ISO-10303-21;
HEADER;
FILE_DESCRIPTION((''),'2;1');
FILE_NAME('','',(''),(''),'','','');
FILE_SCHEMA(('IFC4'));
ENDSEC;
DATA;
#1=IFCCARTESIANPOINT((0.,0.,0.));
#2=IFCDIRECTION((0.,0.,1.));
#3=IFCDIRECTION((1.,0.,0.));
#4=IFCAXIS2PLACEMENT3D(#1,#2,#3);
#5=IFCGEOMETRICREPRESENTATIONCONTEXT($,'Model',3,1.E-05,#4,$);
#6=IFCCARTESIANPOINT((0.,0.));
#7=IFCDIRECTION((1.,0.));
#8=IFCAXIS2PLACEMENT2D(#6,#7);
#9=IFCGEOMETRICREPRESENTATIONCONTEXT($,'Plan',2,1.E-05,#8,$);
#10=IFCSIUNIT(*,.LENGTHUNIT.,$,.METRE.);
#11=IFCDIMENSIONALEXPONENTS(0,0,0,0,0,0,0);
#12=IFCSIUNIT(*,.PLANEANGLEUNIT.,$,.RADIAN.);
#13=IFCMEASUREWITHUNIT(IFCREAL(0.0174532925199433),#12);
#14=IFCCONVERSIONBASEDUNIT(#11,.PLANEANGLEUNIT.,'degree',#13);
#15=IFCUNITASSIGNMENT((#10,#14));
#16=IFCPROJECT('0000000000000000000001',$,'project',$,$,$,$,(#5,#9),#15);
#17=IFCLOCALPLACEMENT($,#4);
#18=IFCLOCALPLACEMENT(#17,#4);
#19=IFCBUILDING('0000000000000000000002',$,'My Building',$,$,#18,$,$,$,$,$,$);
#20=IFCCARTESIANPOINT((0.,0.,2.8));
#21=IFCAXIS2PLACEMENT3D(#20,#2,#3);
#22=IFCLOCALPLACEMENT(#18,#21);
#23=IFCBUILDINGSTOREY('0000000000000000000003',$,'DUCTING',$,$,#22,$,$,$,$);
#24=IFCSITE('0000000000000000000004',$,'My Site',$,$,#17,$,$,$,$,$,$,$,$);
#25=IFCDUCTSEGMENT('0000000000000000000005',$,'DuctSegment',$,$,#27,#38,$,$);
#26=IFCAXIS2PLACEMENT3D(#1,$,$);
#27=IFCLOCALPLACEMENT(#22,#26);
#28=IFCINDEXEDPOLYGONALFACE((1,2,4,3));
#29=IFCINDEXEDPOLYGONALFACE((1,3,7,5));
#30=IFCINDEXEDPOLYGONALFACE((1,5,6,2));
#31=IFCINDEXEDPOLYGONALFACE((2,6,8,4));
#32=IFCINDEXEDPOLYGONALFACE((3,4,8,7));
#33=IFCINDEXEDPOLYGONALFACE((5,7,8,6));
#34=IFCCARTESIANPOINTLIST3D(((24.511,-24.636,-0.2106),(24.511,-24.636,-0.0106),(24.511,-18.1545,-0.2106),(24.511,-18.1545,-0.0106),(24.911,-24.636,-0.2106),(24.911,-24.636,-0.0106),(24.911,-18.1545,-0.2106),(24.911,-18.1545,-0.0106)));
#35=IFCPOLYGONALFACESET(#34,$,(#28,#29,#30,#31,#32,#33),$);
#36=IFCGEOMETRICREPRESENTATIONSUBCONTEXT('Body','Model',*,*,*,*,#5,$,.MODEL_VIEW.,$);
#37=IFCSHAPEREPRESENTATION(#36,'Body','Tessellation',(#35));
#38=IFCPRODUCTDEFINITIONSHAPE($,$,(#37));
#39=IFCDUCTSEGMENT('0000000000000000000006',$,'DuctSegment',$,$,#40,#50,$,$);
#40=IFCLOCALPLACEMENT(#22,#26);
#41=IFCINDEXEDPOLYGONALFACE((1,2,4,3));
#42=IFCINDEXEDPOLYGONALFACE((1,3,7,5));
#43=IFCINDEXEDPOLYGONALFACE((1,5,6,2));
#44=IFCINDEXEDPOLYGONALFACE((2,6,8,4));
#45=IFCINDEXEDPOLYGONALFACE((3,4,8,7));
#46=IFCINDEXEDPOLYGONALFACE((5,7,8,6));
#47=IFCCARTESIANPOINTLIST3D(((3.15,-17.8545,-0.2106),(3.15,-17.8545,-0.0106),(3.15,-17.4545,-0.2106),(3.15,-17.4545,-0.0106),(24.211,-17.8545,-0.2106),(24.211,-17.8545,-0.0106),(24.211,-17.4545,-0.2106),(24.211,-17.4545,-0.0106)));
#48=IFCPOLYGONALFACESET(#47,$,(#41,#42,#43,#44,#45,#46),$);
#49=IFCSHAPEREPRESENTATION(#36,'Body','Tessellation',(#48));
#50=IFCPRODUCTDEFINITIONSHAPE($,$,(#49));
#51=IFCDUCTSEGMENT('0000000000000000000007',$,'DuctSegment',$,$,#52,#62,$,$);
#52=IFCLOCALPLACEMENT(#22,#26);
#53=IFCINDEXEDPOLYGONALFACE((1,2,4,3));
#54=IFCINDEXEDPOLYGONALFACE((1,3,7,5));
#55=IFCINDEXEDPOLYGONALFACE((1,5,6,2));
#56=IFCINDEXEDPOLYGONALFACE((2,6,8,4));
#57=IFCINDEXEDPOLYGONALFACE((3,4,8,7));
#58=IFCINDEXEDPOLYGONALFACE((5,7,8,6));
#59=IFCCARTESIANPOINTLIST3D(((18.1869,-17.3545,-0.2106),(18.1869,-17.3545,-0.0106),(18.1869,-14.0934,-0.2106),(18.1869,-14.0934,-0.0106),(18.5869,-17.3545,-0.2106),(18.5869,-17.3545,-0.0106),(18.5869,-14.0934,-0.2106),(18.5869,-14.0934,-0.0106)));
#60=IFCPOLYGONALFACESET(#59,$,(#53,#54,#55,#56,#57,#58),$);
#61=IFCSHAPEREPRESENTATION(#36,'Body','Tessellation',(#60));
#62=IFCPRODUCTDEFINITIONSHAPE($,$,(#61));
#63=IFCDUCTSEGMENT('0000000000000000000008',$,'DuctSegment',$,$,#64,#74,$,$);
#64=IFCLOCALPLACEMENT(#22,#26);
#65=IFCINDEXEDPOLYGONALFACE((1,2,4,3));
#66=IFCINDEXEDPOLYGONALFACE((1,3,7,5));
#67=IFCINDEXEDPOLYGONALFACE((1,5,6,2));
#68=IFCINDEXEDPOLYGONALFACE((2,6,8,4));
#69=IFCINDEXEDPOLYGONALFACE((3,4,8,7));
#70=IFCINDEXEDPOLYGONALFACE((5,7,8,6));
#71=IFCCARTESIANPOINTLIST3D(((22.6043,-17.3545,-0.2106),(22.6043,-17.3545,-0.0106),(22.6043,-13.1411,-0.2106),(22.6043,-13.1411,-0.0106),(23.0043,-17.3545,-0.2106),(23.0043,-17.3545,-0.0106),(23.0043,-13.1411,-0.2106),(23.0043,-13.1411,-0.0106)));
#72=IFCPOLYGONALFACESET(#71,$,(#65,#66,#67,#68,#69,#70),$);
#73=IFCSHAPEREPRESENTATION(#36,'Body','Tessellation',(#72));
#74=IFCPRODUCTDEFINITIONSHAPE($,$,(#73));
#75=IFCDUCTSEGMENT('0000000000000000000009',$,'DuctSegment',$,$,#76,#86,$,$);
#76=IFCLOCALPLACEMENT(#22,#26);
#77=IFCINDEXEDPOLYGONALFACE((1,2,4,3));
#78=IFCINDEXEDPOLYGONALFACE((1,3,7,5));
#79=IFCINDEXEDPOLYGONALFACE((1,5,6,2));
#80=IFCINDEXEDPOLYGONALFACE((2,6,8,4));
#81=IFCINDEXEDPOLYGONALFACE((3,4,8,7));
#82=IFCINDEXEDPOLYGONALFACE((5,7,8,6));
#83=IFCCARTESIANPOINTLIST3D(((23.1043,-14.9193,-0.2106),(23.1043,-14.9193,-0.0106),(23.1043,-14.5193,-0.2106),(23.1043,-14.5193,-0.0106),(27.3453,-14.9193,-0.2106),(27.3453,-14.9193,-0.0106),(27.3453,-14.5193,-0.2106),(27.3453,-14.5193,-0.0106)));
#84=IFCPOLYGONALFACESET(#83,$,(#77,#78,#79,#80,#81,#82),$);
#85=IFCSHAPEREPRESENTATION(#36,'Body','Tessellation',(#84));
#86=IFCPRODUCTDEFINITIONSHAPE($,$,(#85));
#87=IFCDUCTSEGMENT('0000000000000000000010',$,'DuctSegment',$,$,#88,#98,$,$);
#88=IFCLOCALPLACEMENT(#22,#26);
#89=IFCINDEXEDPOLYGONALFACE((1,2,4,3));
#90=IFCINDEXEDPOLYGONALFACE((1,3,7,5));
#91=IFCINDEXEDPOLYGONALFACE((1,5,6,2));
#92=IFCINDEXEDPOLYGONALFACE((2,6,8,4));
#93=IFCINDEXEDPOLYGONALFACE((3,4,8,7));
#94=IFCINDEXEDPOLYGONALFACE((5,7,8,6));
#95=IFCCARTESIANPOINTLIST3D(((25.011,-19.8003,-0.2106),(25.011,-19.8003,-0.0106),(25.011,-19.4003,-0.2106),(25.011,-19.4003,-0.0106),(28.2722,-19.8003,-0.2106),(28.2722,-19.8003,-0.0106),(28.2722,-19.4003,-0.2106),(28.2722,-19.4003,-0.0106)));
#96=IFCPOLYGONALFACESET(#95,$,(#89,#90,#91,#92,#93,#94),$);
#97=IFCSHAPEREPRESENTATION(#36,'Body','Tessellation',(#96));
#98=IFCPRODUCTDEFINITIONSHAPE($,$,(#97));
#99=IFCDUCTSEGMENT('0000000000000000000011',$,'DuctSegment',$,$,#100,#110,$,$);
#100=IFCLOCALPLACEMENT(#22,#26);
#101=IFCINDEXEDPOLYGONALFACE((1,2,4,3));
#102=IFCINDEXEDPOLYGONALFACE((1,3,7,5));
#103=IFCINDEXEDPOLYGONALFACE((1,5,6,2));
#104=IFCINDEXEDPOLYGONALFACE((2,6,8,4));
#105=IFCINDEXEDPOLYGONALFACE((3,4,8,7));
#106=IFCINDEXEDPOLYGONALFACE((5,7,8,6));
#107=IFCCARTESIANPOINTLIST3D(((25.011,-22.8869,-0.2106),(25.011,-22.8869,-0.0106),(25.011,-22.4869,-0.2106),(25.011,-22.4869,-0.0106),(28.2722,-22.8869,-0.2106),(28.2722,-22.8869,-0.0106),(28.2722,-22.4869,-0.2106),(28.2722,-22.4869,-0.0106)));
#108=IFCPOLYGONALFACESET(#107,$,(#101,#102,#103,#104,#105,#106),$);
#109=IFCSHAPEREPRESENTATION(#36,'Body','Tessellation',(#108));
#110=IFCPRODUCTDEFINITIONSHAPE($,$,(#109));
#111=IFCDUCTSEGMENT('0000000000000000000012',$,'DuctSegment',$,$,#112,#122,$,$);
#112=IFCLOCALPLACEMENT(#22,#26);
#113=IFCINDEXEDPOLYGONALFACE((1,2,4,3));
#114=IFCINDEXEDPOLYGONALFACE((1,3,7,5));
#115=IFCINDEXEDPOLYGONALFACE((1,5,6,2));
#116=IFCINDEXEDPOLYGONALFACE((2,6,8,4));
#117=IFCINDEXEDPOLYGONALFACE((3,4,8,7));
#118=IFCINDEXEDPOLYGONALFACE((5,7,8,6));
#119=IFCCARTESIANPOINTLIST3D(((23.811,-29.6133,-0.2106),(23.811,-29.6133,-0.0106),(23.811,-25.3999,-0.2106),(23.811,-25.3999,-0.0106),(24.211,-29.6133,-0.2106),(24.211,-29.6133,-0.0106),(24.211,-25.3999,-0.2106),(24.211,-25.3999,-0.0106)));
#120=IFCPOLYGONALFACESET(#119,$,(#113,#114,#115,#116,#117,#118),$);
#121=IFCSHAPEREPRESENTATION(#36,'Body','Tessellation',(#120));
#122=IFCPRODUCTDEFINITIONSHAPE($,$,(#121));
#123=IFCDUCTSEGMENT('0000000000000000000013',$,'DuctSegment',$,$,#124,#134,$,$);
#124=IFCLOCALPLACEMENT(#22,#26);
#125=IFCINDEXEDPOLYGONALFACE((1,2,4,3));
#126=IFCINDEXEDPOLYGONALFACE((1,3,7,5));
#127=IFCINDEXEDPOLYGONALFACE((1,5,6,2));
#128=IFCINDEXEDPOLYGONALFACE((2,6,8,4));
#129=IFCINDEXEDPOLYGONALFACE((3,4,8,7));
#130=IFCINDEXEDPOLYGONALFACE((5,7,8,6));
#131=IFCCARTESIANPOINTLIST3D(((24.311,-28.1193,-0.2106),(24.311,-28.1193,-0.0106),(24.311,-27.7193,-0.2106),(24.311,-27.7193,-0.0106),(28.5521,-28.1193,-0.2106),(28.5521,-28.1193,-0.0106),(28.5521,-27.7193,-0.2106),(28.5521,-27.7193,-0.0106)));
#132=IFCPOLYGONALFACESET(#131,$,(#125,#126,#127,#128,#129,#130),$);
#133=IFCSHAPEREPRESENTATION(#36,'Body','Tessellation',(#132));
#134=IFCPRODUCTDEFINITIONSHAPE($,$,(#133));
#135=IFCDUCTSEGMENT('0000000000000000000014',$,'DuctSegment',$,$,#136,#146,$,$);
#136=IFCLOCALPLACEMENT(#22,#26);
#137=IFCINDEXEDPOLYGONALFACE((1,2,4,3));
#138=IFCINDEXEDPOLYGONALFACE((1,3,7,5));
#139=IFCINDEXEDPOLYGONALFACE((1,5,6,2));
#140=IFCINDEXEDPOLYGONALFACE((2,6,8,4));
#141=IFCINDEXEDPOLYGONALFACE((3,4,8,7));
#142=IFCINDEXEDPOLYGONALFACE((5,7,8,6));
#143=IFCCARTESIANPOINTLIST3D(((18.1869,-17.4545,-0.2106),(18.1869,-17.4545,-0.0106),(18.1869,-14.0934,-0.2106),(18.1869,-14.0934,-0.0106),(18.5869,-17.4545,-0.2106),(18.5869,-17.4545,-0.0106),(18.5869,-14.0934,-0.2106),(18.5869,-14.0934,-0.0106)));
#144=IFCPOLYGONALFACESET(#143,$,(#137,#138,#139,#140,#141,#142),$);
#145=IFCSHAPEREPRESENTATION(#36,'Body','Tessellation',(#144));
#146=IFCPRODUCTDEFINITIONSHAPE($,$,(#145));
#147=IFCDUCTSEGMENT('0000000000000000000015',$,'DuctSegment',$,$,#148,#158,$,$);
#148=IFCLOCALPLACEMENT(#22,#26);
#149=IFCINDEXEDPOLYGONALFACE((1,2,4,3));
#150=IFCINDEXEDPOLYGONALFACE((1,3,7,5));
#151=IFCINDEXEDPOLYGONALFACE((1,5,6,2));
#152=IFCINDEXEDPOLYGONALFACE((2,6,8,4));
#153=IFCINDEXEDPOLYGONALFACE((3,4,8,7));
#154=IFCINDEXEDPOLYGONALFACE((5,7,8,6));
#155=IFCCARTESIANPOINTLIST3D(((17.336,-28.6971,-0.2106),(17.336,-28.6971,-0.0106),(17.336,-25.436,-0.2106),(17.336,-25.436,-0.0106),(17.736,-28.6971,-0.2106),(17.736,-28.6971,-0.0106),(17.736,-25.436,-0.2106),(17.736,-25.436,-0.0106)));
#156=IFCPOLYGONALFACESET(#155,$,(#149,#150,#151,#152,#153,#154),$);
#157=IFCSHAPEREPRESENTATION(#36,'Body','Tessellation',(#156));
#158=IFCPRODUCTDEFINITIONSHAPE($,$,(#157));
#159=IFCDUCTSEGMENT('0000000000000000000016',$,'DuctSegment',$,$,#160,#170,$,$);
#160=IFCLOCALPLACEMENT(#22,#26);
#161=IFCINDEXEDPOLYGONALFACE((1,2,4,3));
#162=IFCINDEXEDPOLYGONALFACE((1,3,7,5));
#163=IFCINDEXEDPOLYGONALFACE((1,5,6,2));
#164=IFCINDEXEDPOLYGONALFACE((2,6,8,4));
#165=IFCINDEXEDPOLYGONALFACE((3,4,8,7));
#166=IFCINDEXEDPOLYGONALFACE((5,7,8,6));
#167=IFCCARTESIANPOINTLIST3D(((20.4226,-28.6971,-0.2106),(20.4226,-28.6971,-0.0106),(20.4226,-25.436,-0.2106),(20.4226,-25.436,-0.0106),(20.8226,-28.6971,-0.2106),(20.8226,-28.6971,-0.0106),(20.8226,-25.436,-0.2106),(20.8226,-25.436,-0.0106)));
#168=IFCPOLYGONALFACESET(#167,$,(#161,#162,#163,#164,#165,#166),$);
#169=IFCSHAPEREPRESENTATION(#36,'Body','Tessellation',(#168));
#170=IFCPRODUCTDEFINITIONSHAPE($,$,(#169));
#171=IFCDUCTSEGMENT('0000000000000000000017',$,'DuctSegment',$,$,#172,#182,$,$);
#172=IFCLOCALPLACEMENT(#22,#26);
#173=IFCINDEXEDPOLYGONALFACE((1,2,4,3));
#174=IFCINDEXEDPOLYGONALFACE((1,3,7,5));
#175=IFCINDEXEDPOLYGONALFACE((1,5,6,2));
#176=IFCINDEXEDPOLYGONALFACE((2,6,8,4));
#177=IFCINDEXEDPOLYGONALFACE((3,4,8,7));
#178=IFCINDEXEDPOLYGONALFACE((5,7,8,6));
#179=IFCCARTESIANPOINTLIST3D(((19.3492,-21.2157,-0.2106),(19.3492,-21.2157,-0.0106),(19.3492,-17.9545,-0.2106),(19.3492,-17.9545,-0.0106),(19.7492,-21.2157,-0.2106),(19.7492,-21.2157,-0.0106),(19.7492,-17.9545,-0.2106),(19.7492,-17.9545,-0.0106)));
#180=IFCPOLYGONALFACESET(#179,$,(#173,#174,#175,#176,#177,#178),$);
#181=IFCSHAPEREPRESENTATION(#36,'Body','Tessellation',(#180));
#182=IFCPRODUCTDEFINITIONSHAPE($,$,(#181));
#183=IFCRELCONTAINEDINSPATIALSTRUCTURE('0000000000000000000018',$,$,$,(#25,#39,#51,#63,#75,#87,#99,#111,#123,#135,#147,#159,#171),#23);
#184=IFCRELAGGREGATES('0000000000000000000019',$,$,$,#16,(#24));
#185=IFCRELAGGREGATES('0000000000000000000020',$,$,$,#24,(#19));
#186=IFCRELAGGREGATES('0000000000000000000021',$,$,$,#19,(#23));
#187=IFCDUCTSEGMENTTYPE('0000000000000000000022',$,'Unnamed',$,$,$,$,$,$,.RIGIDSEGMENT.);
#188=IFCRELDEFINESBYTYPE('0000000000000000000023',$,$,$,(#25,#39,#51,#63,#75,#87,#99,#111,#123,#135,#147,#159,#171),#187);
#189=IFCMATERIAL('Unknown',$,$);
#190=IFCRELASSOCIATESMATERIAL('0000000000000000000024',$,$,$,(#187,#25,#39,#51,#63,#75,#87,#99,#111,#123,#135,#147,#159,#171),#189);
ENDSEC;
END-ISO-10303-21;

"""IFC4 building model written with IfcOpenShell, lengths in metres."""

from ifc_helpers import new_model, entity, si_unit, converted_unit, frame, origin_with_axes, origin_2d_with_axis, place, context, subcontext, project, spatial, rectangle, extrude, material, material_profile, profile_set, profile_usage, type_object, element, save


model = new_model("IFC4")

# Units and contexts
model_context = context("Model", 3, precision=1e-05, world=origin_with_axes())
plan_context = context("Plan", 2, precision=1e-05, world=origin_2d_with_axis())
body_context = subcontext(model_context, "Body", "Model", "MODEL_VIEW")
ifc_project = project(units=[si_unit("LENGTHUNIT", "METRE"), converted_unit("PLANEANGLEUNIT", "degree", entity("IfcReal", 0.0174532925199433), si_unit("PLANEANGLEUNIT", "RADIAN"), dimensions=[0, 0, 0, 0, 0, 0, 0])], contexts=[model_context, plan_context])

# Site, building, storey
site_placement = place(None, origin_with_axes())
site = spatial("IfcSite", under=ifc_project, at=site_placement, Name="My Site")
building_placement = place(site_placement, origin_with_axes())
building = spatial("IfcBuilding", under=site, at=building_placement, Name="My Building")
storey_placement = place(building_placement, frame((0.0, 0.0, 2.8), z_axis=(0.0, 0.0, 1.0), x_axis=(1.0, 0.0, 0.0)))
storey = spatial("IfcBuildingStorey", under=building, at=storey_placement, Name="DUCTING")

# Duct segments
ifc_material = material(Name="Unknown")
ifc_material_profile_1 = material_profile(ifc_material, rectangle(XDim=0.4, YDim=0.2))
ifc_profile_set_1 = profile_set([ifc_material_profile_1])
ifc_profile_usage_1 = profile_usage(ifc_profile_set_1, cardinal=5)
duct_segment_type = type_object("IfcDuctSegmentType", Name="Unnamed", PredefinedType="RIGIDSEGMENT", material=ifc_profile_set_1)
duct_segment_1_placement = place(storey_placement, frame((24.711, -24.636, -0.1106), z_axis=(0.0, 1.0, 0.0), x_axis=(-1.0, 0.0, 0.0)))
element("IfcDuctSegment", 1, at=duct_segment_1_placement, inside=storey, type_object=duct_segment_type, material=ifc_profile_usage_1, Name="DuctSegment", context=body_context, shape_type="SweptSolid", body=[
    extrude(rectangle(XDim=0.4, YDim=0.2), origin_with_axes(), (0.0, 0.0, 1.0), 6.4815),
])
ifc_profile_usage_2 = profile_usage(ifc_profile_set_1, cardinal=5)
duct_segment_2_placement = place(storey_placement, frame((24.211, -17.6545, -0.1106), z_axis=(-1.0, 0.0, 0.0), x_axis=(0.0, -1.0, 0.0)))
element("IfcDuctSegment", 2, at=duct_segment_2_placement, inside=storey, type_object=duct_segment_type, material=ifc_profile_usage_2, Name="DuctSegment", context=body_context, shape_type="SweptSolid", body=[
    extrude(rectangle(XDim=0.4, YDim=0.2), origin_with_axes(), (0.0, 0.0, 1.0), 21.061),
])
ifc_profile_usage_3 = profile_usage(ifc_profile_set_1, cardinal=5)
duct_segment_3_placement = place(storey_placement, frame((18.3869, -17.3545, -0.1106), z_axis=(0.0, 1.0, 0.0), x_axis=(-1.0, 0.0, 0.0)))
element("IfcDuctSegment", 3, at=duct_segment_3_placement, inside=storey, type_object=duct_segment_type, material=ifc_profile_usage_3, Name="DuctSegment", context=body_context, shape_type="SweptSolid", body=[
    extrude(rectangle(XDim=0.4, YDim=0.2), origin_with_axes(), (0.0, 0.0, 1.0), 3.2611),
])
ifc_profile_usage_4 = profile_usage(ifc_profile_set_1, cardinal=5)
duct_segment_4_placement = place(storey_placement, frame((22.8043, -17.3545, -0.1106), z_axis=(0.0, 1.0, 0.0), x_axis=(-1.0, 0.0, 0.0)))
element("IfcDuctSegment", 4, at=duct_segment_4_placement, inside=storey, type_object=duct_segment_type, material=ifc_profile_usage_4, Name="DuctSegment", context=body_context, shape_type="SweptSolid", body=[
    extrude(rectangle(XDim=0.4, YDim=0.2), origin_with_axes(), (0.0, 0.0, 1.0), 4.2134),
])
ifc_profile_usage_5 = profile_usage(ifc_profile_set_1, cardinal=5)
duct_segment_5_placement = place(storey_placement, frame((23.1043, -14.7193, -0.1106), z_axis=(1.0, 0.0, 0.0), x_axis=(0.0, 1.0, 0.0)))
element("IfcDuctSegment", 5, at=duct_segment_5_placement, inside=storey, type_object=duct_segment_type, material=ifc_profile_usage_5, Name="DuctSegment", context=body_context, shape_type="SweptSolid", body=[
    extrude(rectangle(XDim=0.4, YDim=0.2), origin_with_axes(), (0.0, 0.0, 1.0), 4.241),
])
ifc_profile_usage_6 = profile_usage(ifc_profile_set_1, cardinal=5)
duct_segment_6_placement = place(storey_placement, frame((25.011, -19.6003, -0.1106), z_axis=(1.0, 0.0, 0.0), x_axis=(0.0, 1.0, 0.0)))
element("IfcDuctSegment", 6, at=duct_segment_6_placement, inside=storey, type_object=duct_segment_type, material=ifc_profile_usage_6, Name="DuctSegment", context=body_context, shape_type="SweptSolid", body=[
    extrude(rectangle(XDim=0.4, YDim=0.2), origin_with_axes(), (0.0, 0.0, 1.0), 3.2611),
])
ifc_profile_usage_7 = profile_usage(ifc_profile_set_1, cardinal=5)
duct_segment_7_placement = place(storey_placement, frame((25.011, -22.6869, -0.1106), z_axis=(1.0, 0.0, 0.0), x_axis=(0.0, 1.0, 0.0)))
element("IfcDuctSegment", 7, at=duct_segment_7_placement, inside=storey, type_object=duct_segment_type, material=ifc_profile_usage_7, Name="DuctSegment", context=body_context, shape_type="SweptSolid", body=[
    extrude(rectangle(XDim=0.4, YDim=0.2), origin_with_axes(), (0.0, 0.0, 1.0), 3.2611),
])
ifc_profile_usage_8 = profile_usage(ifc_profile_set_1, cardinal=5)
duct_segment_8_placement = place(storey_placement, frame((24.011, -29.6133, -0.1106), z_axis=(0.0, 1.0, 0.0), x_axis=(-1.0, 0.0, 0.0)))
element("IfcDuctSegment", 8, at=duct_segment_8_placement, inside=storey, type_object=duct_segment_type, material=ifc_profile_usage_8, Name="DuctSegment", context=body_context, shape_type="SweptSolid", body=[
    extrude(rectangle(XDim=0.4, YDim=0.2), origin_with_axes(), (0.0, 0.0, 1.0), 4.2134),
])
ifc_profile_usage_9 = profile_usage(ifc_profile_set_1, cardinal=5)
duct_segment_9_placement = place(storey_placement, frame((24.311, -27.9193, -0.1106), z_axis=(1.0, 0.0, 0.0), x_axis=(0.0, 1.0, 0.0)))
element("IfcDuctSegment", 9, at=duct_segment_9_placement, inside=storey, type_object=duct_segment_type, material=ifc_profile_usage_9, Name="DuctSegment", context=body_context, shape_type="SweptSolid", body=[
    extrude(rectangle(XDim=0.4, YDim=0.2), origin_with_axes(), (0.0, 0.0, 1.0), 4.241),
])
ifc_profile_usage_10 = profile_usage(ifc_profile_set_1, cardinal=5)
duct_segment_10_placement = place(storey_placement, frame((18.3869, -17.4545, -0.1106), z_axis=(0.0, 1.0, 0.0), x_axis=(-1.0, 0.0, 0.0)))
element("IfcDuctSegment", 10, at=duct_segment_10_placement, inside=storey, type_object=duct_segment_type, material=ifc_profile_usage_10, Name="DuctSegment", context=body_context, shape_type="SweptSolid", body=[
    extrude(rectangle(XDim=0.4, YDim=0.2), origin_with_axes(), (0.0, 0.0, 1.0), 3.3611),
])
ifc_profile_usage_11 = profile_usage(ifc_profile_set_1, cardinal=5)
duct_segment_11_placement = place(storey_placement, frame((17.536, -28.6971, -0.1106), z_axis=(0.0, 1.0, 0.0), x_axis=(-1.0, 0.0, 0.0)))
element("IfcDuctSegment", 11, at=duct_segment_11_placement, inside=storey, type_object=duct_segment_type, material=ifc_profile_usage_11, Name="DuctSegment", context=body_context, shape_type="SweptSolid", body=[
    extrude(rectangle(XDim=0.4, YDim=0.2), origin_with_axes(), (0.0, 0.0, 1.0), 3.2611),
])
ifc_profile_usage_12 = profile_usage(ifc_profile_set_1, cardinal=5)
duct_segment_12_placement = place(storey_placement, frame((20.6226, -28.6971, -0.1106), z_axis=(0.0, 1.0, 0.0), x_axis=(-1.0, 0.0, 0.0)))
element("IfcDuctSegment", 12, at=duct_segment_12_placement, inside=storey, type_object=duct_segment_type, material=ifc_profile_usage_12, Name="DuctSegment", context=body_context, shape_type="SweptSolid", body=[
    extrude(rectangle(XDim=0.4, YDim=0.2), origin_with_axes(), (0.0, 0.0, 1.0), 3.2611),
])
ifc_profile_usage_13 = profile_usage(ifc_profile_set_1, cardinal=5)
duct_segment_13_placement = place(storey_placement, frame((19.5492, -21.2157, -0.1106), z_axis=(0.0, 1.0, 0.0), x_axis=(-1.0, 0.0, 0.0)))
element("IfcDuctSegment", 13, at=duct_segment_13_placement, inside=storey, type_object=duct_segment_type, material=ifc_profile_usage_13, Name="DuctSegment", context=body_context, shape_type="SweptSolid", body=[
    extrude(rectangle(XDim=0.4, YDim=0.2), origin_with_axes(), (0.0, 0.0, 1.0), 3.2611),
])

save(model, "model.ifc")
